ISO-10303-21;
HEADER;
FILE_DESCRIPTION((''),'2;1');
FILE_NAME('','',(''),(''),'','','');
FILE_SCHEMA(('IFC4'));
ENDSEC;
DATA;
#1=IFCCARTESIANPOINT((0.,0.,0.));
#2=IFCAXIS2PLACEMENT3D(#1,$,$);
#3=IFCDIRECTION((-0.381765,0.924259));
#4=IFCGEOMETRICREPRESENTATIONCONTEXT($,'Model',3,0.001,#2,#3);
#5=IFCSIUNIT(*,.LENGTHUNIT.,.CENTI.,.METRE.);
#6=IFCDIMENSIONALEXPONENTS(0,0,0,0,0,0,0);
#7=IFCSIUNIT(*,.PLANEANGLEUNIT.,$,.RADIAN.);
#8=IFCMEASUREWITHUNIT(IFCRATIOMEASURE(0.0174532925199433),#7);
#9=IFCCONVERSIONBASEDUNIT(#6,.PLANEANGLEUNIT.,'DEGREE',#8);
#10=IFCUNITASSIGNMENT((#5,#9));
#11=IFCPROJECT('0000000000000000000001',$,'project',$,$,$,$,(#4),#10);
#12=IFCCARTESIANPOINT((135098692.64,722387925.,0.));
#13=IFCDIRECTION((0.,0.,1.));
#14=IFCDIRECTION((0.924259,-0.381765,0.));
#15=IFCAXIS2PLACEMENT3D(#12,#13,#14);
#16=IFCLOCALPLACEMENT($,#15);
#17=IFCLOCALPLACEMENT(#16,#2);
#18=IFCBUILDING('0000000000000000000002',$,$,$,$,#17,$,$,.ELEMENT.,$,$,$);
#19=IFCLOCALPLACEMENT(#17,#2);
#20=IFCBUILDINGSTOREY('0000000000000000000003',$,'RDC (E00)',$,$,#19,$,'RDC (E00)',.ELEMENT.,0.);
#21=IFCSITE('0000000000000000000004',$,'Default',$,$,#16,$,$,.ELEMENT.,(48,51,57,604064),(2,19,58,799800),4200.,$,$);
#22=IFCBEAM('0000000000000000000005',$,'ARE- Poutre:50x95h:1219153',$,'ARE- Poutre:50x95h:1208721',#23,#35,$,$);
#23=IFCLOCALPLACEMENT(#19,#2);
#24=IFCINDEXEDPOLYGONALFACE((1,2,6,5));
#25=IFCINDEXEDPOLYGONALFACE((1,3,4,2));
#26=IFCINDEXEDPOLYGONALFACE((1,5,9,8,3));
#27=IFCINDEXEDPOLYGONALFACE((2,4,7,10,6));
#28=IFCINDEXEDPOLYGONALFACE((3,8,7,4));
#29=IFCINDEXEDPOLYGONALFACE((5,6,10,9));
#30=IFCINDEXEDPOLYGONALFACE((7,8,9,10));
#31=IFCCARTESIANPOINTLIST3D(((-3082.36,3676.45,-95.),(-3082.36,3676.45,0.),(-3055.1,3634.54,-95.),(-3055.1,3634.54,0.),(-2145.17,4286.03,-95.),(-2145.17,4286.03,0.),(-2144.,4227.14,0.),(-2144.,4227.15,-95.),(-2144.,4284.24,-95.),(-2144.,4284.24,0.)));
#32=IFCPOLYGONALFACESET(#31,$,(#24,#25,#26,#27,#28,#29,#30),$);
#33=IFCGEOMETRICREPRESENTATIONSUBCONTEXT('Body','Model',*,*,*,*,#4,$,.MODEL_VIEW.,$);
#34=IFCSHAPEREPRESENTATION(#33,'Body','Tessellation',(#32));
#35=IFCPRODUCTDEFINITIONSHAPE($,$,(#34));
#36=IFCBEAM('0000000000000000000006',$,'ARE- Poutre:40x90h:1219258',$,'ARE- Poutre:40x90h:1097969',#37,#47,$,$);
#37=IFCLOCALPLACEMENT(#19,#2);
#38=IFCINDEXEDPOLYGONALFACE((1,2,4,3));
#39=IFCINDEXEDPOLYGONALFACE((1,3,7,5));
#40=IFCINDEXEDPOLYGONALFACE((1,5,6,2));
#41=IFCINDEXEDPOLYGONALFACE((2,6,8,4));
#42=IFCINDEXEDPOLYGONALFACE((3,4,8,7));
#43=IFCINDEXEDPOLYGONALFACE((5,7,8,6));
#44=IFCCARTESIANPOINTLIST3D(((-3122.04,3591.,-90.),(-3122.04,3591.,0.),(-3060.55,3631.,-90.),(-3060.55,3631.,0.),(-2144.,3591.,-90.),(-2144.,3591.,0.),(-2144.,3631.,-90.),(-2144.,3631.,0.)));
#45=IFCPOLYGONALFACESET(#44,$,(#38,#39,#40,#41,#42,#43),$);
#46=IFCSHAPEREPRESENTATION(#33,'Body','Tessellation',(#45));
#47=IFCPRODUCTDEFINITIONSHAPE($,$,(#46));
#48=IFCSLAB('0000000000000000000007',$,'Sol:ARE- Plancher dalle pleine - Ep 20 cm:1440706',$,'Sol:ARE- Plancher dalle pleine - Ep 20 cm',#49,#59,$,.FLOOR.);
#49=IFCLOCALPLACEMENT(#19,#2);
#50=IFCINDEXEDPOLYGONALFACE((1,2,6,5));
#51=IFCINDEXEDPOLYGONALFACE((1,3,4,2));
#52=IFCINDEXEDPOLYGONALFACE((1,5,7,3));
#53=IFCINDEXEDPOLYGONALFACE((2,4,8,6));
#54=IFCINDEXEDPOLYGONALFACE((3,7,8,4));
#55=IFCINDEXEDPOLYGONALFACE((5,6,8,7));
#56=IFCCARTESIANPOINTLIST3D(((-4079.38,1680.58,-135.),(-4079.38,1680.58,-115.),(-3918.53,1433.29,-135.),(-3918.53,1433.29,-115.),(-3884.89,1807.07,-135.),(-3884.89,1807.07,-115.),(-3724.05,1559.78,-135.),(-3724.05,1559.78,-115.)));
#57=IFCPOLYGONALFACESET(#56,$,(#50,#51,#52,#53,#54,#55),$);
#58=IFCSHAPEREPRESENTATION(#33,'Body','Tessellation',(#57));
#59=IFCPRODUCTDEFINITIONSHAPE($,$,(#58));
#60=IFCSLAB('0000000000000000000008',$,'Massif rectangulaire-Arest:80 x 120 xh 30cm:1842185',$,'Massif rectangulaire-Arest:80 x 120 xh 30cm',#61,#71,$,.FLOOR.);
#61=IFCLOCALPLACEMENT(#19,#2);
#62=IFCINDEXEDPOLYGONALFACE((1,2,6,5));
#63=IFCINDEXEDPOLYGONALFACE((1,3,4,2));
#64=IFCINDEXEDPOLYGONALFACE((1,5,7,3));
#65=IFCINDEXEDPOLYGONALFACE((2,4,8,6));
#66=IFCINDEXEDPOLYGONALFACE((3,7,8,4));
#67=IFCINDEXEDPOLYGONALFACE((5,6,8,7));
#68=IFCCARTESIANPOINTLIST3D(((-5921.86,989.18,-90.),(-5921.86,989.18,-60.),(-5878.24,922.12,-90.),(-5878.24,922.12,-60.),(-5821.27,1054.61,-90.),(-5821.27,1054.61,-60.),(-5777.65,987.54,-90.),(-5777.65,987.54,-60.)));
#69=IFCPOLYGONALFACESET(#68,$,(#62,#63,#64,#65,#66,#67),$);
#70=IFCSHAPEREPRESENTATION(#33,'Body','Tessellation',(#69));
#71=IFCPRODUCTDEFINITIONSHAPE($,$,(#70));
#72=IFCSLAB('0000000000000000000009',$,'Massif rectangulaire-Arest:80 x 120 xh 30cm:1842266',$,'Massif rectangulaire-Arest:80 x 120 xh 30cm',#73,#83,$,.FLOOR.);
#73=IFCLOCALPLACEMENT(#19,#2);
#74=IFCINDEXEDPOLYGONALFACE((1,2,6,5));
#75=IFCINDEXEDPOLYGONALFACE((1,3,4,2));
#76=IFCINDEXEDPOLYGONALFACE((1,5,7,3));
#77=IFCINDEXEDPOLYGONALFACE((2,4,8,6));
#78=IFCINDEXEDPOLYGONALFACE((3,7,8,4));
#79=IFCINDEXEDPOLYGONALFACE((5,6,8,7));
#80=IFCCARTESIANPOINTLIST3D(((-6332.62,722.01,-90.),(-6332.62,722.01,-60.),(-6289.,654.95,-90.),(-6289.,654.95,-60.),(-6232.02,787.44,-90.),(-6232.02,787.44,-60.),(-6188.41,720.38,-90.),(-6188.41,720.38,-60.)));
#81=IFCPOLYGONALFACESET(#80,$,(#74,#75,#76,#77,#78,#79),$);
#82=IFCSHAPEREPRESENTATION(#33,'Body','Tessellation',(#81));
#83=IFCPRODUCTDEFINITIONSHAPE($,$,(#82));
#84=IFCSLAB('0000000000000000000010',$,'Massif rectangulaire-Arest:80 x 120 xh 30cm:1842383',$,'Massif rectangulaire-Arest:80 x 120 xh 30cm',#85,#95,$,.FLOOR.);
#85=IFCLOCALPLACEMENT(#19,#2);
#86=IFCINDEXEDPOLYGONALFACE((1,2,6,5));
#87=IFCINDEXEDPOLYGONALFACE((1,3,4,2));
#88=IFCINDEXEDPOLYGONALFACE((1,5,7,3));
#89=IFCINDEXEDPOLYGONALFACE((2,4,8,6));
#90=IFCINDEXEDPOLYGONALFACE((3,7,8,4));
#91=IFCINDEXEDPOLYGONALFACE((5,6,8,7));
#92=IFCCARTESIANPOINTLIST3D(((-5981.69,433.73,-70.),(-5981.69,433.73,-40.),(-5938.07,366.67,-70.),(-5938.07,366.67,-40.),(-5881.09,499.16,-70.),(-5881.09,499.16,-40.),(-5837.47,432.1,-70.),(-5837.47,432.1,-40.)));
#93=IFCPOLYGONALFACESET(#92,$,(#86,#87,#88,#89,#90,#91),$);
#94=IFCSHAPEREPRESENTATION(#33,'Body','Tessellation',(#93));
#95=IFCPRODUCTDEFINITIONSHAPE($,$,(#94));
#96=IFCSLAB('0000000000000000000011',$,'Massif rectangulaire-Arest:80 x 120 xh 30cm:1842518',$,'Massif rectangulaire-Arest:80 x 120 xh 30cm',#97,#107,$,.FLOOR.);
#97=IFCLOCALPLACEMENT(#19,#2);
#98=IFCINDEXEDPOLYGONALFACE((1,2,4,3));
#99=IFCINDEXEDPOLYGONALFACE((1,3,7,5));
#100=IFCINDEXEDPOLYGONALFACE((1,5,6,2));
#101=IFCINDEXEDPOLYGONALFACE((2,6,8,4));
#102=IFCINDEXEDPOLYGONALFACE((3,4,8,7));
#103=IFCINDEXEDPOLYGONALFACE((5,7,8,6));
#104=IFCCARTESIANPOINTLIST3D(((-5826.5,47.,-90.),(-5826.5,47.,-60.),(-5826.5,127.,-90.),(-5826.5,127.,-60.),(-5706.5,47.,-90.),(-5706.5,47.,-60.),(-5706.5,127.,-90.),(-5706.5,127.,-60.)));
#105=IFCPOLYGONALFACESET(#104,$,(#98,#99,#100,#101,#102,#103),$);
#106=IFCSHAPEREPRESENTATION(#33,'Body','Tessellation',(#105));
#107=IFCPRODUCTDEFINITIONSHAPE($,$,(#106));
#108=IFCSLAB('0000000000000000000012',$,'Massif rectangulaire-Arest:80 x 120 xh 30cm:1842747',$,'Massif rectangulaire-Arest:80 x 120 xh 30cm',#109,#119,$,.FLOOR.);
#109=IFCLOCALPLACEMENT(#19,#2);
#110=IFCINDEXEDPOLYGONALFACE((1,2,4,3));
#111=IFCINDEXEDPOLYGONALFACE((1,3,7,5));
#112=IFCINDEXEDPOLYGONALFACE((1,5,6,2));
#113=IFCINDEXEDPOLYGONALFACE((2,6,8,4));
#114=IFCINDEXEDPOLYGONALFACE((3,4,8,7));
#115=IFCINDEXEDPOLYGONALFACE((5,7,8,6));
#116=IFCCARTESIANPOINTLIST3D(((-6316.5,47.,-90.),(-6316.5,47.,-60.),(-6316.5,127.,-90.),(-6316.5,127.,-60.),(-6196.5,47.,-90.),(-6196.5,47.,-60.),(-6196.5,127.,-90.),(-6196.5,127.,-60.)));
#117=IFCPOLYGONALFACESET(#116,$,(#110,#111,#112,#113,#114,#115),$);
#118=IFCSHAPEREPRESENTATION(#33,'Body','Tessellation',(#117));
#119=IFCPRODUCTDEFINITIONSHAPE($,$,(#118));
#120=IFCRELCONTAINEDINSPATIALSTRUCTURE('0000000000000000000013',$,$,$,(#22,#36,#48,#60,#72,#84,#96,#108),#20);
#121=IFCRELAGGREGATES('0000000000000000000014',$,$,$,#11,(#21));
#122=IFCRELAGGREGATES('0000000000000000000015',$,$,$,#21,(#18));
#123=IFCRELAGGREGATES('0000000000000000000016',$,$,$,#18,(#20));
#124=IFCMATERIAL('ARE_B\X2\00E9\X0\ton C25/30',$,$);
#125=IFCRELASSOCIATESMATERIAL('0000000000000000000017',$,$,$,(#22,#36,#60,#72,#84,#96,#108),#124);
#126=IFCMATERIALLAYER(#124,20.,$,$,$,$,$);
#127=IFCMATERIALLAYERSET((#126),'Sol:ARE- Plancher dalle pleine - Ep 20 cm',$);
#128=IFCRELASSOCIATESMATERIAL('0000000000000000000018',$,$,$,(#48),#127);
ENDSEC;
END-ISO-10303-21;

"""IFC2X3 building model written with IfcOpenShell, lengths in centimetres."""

from ifc_helpers import new_model, entity, si_unit, converted_unit, direction, frame, frame_2d, origin, place, context, subcontext, project, spatial, rectangle, extrude, clip, halfspace, material, layer, layer_set, layer_usage, element, save


model = new_model("IFC2X3")

# Units and contexts
model_context = context("Model", 3, precision=0.001, world=origin(), true_north=direction((-0.381765, 0.924259)))
body_context = subcontext(model_context, "Body", "Model", "MODEL_VIEW")
ifc_project = project(units=[si_unit("LENGTHUNIT", "METRE", prefix="CENTI"), converted_unit("PLANEANGLEUNIT", "DEGREE", entity("IfcRatioMeasure", 0.0174532925199433), si_unit("PLANEANGLEUNIT", "RADIAN"), dimensions=[0, 0, 0, 0, 0, 0, 0])], contexts=[model_context])

# Site, building, storey
site_placement = place(None, frame((135098692.64, 722387925.0, 0.0), z_axis=(0.0, 0.0, 1.0), x_axis=(0.924259, -0.381765, 0.0)))
site = spatial("IfcSite", under=ifc_project, at=site_placement, Name="Default", CompositionType="ELEMENT", RefLatitude=(48, 51, 57, 604064), RefLongitude=(2, 19, 58, 799800), RefElevation=4200.0)
building_placement = place(site_placement, origin())
building = spatial("IfcBuilding", under=site, at=building_placement, CompositionType="ELEMENT")
storey_placement = place(building_placement, origin())
storey = spatial("IfcBuildingStorey", under=building, at=storey_placement, Name="RDC (E00)", LongName="RDC (E00)", CompositionType="ELEMENT", Elevation=0.0)

# Beams
ifc_material = material(Name="ARE_Béton C25/30")
beam_1_placement = place(storey_placement, frame((-3068.73, 3655.5, 0.0), z_axis=(0.0, 0.0, 1.0), x_axis=(0.838281, 0.545239, 0.0)))
element("IfcBeam", 1, at=beam_1_placement, inside=storey, material=ifc_material, Name="ARE- Poutre:50x95h:1219153", ObjectType="ARE- Poutre:50x95h:1208721", context=body_context, shape_type="Clipping", body=[
    clip(extrude(rectangle(XDim=95.0, YDim=50.0, at=frame_2d((0.0, 0.0), x_axis=(1.0, 0.000006))), frame((0.0, 0.0, -47.5), z_axis=(1.0, 0.0, 0.0), x_axis=(0.0, 0.0, -1.0)), (0.0, 0.0, 1.0), 1118.0), halfspace(frame((1119.39, 25.0, 0.0), z_axis=(0.838279, -0.545241, 0.0), x_axis=(0.0, 0.0, -1.0)), False)),
])
beam_2_placement = place(storey_placement, frame((-3091.3, 3611.0, 0.0)))
element("IfcBeam", 2, at=beam_2_placement, inside=storey, material=ifc_material, Name="ARE- Poutre:40x90h:1219258", ObjectType="ARE- Poutre:40x90h:1097969", context=body_context, shape_type="Clipping", body=[
    clip(extrude(rectangle(XDim=90.0, YDim=40.0, at=frame_2d((0.0, 0.0), x_axis=(1.0, 0.0))), frame((-30.75, 0.0, -45.0), z_axis=(1.0, 0.0, 0.0), x_axis=(0.0, 0.0, -1.0)), (0.0, 0.0, 1.0), 978.04), halfspace(frame((-47.64, -30.98, 0.0), z_axis=(-0.545236, 0.838282, 0.0), x_axis=(0.0, 0.0, -1.0)), False)),
])

# Slabs
ifc_layer_1 = layer(ifc_material, 20.0)
ifc_layer_set_1 = layer_set([ifc_layer_1], Name="Sol:ARE- Plancher dalle pleine - Ep 20 cm")
ifc_layer_usage_1 = layer_usage(ifc_layer_set_1, "AXIS3", "POSITIVE", 0.0)
slab_1_placement = place(storey_placement, origin())
element("IfcSlab", 3, at=slab_1_placement, inside=storey, material=ifc_layer_usage_1, Name="Sol:ARE- Plancher dalle pleine - Ep 20 cm:1440706", ObjectType="Sol:ARE- Plancher dalle pleine - Ep 20 cm", PredefinedType="FLOOR", context=body_context, shape_type="SweptSolid", body=[
    extrude(rectangle(XDim=295.0, YDim=232.0, at=frame_2d((0.0, 0.0), x_axis=(1.0, 0.0))), frame((-3901.71, 1620.18, -115.0), z_axis=(0.0, 0.0, -1.0), x_axis=(0.545236, -0.838282, 0.0)), (0.0, 0.0, 1.0), 20.0),
])
slab_2_placement = place(storey_placement, origin())
element("IfcSlab", 4, at=slab_2_placement, inside=storey, material=ifc_material, Name="Massif rectangulaire-Arest:80 x 120 xh 30cm:1842185", ObjectType="Massif rectangulaire-Arest:80 x 120 xh 30cm", PredefinedType="FLOOR", context=body_context, shape_type="SweptSolid", body=[
    extrude(rectangle(XDim=80.0, YDim=120.0, at=frame_2d((0.0, 0.0), x_axis=(1.0, 0.0))), frame((-5849.75, 988.36, -90.0), z_axis=(0.0, 0.0, 1.0), x_axis=(0.545236, -0.838282, 0.0)), (0.0, 0.0, 1.0), 30.0),
])
slab_3_placement = place(storey_placement, origin())
element("IfcSlab", 5, at=slab_3_placement, inside=storey, material=ifc_material, Name="Massif rectangulaire-Arest:80 x 120 xh 30cm:1842266", ObjectType="Massif rectangulaire-Arest:80 x 120 xh 30cm", PredefinedType="FLOOR", context=body_context, shape_type="SweptSolid", body=[
    extrude(rectangle(XDim=80.0, YDim=120.0, at=frame_2d((0.0, 0.0), x_axis=(1.0, 0.0))), frame((-6260.51, 721.19, -90.0), z_axis=(0.0, 0.0, 1.0), x_axis=(0.545236, -0.838282, 0.0)), (0.0, 0.0, 1.0), 30.0),
])
slab_4_placement = place(storey_placement, origin())
element("IfcSlab", 6, at=slab_4_placement, inside=storey, material=ifc_material, Name="Massif rectangulaire-Arest:80 x 120 xh 30cm:1842383", ObjectType="Massif rectangulaire-Arest:80 x 120 xh 30cm", PredefinedType="FLOOR", context=body_context, shape_type="SweptSolid", body=[
    extrude(rectangle(XDim=80.0, YDim=120.0, at=frame_2d((0.0, 0.0), x_axis=(1.0, 0.0))), frame((-5909.58, 432.91, -70.0), z_axis=(0.0, 0.0, 1.0), x_axis=(0.545236, -0.838282, 0.0)), (0.0, 0.0, 1.0), 30.0),
])
slab_5_placement = place(storey_placement, origin())
element("IfcSlab", 7, at=slab_5_placement, inside=storey, material=ifc_material, Name="Massif rectangulaire-Arest:80 x 120 xh 30cm:1842518", ObjectType="Massif rectangulaire-Arest:80 x 120 xh 30cm", PredefinedType="FLOOR", context=body_context, shape_type="SweptSolid", body=[
    extrude(rectangle(XDim=80.0, YDim=120.0, at=frame_2d((0.0, 0.0), x_axis=(1.0, 0.0))), frame((-5766.5, 87.0, -90.0), z_axis=(0.0, 0.0, 1.0), x_axis=(0.0, 1.0, 0.0)), (0.0, 0.0, 1.0), 30.0),
])
slab_6_placement = place(storey_placement, origin())
element("IfcSlab", 8, at=slab_6_placement, inside=storey, material=ifc_material, Name="Massif rectangulaire-Arest:80 x 120 xh 30cm:1842747", ObjectType="Massif rectangulaire-Arest:80 x 120 xh 30cm", PredefinedType="FLOOR", context=body_context, shape_type="SweptSolid", body=[
    extrude(rectangle(XDim=80.0, YDim=120.0, at=frame_2d((0.0, 0.0), x_axis=(1.0, 0.0))), frame((-6256.5, 87.0, -90.0), z_axis=(0.0, 0.0, 1.0), x_axis=(0.0, 1.0, 0.0)), (0.0, 0.0, 1.0), 30.0),
])

save(model, "model.ifc")
